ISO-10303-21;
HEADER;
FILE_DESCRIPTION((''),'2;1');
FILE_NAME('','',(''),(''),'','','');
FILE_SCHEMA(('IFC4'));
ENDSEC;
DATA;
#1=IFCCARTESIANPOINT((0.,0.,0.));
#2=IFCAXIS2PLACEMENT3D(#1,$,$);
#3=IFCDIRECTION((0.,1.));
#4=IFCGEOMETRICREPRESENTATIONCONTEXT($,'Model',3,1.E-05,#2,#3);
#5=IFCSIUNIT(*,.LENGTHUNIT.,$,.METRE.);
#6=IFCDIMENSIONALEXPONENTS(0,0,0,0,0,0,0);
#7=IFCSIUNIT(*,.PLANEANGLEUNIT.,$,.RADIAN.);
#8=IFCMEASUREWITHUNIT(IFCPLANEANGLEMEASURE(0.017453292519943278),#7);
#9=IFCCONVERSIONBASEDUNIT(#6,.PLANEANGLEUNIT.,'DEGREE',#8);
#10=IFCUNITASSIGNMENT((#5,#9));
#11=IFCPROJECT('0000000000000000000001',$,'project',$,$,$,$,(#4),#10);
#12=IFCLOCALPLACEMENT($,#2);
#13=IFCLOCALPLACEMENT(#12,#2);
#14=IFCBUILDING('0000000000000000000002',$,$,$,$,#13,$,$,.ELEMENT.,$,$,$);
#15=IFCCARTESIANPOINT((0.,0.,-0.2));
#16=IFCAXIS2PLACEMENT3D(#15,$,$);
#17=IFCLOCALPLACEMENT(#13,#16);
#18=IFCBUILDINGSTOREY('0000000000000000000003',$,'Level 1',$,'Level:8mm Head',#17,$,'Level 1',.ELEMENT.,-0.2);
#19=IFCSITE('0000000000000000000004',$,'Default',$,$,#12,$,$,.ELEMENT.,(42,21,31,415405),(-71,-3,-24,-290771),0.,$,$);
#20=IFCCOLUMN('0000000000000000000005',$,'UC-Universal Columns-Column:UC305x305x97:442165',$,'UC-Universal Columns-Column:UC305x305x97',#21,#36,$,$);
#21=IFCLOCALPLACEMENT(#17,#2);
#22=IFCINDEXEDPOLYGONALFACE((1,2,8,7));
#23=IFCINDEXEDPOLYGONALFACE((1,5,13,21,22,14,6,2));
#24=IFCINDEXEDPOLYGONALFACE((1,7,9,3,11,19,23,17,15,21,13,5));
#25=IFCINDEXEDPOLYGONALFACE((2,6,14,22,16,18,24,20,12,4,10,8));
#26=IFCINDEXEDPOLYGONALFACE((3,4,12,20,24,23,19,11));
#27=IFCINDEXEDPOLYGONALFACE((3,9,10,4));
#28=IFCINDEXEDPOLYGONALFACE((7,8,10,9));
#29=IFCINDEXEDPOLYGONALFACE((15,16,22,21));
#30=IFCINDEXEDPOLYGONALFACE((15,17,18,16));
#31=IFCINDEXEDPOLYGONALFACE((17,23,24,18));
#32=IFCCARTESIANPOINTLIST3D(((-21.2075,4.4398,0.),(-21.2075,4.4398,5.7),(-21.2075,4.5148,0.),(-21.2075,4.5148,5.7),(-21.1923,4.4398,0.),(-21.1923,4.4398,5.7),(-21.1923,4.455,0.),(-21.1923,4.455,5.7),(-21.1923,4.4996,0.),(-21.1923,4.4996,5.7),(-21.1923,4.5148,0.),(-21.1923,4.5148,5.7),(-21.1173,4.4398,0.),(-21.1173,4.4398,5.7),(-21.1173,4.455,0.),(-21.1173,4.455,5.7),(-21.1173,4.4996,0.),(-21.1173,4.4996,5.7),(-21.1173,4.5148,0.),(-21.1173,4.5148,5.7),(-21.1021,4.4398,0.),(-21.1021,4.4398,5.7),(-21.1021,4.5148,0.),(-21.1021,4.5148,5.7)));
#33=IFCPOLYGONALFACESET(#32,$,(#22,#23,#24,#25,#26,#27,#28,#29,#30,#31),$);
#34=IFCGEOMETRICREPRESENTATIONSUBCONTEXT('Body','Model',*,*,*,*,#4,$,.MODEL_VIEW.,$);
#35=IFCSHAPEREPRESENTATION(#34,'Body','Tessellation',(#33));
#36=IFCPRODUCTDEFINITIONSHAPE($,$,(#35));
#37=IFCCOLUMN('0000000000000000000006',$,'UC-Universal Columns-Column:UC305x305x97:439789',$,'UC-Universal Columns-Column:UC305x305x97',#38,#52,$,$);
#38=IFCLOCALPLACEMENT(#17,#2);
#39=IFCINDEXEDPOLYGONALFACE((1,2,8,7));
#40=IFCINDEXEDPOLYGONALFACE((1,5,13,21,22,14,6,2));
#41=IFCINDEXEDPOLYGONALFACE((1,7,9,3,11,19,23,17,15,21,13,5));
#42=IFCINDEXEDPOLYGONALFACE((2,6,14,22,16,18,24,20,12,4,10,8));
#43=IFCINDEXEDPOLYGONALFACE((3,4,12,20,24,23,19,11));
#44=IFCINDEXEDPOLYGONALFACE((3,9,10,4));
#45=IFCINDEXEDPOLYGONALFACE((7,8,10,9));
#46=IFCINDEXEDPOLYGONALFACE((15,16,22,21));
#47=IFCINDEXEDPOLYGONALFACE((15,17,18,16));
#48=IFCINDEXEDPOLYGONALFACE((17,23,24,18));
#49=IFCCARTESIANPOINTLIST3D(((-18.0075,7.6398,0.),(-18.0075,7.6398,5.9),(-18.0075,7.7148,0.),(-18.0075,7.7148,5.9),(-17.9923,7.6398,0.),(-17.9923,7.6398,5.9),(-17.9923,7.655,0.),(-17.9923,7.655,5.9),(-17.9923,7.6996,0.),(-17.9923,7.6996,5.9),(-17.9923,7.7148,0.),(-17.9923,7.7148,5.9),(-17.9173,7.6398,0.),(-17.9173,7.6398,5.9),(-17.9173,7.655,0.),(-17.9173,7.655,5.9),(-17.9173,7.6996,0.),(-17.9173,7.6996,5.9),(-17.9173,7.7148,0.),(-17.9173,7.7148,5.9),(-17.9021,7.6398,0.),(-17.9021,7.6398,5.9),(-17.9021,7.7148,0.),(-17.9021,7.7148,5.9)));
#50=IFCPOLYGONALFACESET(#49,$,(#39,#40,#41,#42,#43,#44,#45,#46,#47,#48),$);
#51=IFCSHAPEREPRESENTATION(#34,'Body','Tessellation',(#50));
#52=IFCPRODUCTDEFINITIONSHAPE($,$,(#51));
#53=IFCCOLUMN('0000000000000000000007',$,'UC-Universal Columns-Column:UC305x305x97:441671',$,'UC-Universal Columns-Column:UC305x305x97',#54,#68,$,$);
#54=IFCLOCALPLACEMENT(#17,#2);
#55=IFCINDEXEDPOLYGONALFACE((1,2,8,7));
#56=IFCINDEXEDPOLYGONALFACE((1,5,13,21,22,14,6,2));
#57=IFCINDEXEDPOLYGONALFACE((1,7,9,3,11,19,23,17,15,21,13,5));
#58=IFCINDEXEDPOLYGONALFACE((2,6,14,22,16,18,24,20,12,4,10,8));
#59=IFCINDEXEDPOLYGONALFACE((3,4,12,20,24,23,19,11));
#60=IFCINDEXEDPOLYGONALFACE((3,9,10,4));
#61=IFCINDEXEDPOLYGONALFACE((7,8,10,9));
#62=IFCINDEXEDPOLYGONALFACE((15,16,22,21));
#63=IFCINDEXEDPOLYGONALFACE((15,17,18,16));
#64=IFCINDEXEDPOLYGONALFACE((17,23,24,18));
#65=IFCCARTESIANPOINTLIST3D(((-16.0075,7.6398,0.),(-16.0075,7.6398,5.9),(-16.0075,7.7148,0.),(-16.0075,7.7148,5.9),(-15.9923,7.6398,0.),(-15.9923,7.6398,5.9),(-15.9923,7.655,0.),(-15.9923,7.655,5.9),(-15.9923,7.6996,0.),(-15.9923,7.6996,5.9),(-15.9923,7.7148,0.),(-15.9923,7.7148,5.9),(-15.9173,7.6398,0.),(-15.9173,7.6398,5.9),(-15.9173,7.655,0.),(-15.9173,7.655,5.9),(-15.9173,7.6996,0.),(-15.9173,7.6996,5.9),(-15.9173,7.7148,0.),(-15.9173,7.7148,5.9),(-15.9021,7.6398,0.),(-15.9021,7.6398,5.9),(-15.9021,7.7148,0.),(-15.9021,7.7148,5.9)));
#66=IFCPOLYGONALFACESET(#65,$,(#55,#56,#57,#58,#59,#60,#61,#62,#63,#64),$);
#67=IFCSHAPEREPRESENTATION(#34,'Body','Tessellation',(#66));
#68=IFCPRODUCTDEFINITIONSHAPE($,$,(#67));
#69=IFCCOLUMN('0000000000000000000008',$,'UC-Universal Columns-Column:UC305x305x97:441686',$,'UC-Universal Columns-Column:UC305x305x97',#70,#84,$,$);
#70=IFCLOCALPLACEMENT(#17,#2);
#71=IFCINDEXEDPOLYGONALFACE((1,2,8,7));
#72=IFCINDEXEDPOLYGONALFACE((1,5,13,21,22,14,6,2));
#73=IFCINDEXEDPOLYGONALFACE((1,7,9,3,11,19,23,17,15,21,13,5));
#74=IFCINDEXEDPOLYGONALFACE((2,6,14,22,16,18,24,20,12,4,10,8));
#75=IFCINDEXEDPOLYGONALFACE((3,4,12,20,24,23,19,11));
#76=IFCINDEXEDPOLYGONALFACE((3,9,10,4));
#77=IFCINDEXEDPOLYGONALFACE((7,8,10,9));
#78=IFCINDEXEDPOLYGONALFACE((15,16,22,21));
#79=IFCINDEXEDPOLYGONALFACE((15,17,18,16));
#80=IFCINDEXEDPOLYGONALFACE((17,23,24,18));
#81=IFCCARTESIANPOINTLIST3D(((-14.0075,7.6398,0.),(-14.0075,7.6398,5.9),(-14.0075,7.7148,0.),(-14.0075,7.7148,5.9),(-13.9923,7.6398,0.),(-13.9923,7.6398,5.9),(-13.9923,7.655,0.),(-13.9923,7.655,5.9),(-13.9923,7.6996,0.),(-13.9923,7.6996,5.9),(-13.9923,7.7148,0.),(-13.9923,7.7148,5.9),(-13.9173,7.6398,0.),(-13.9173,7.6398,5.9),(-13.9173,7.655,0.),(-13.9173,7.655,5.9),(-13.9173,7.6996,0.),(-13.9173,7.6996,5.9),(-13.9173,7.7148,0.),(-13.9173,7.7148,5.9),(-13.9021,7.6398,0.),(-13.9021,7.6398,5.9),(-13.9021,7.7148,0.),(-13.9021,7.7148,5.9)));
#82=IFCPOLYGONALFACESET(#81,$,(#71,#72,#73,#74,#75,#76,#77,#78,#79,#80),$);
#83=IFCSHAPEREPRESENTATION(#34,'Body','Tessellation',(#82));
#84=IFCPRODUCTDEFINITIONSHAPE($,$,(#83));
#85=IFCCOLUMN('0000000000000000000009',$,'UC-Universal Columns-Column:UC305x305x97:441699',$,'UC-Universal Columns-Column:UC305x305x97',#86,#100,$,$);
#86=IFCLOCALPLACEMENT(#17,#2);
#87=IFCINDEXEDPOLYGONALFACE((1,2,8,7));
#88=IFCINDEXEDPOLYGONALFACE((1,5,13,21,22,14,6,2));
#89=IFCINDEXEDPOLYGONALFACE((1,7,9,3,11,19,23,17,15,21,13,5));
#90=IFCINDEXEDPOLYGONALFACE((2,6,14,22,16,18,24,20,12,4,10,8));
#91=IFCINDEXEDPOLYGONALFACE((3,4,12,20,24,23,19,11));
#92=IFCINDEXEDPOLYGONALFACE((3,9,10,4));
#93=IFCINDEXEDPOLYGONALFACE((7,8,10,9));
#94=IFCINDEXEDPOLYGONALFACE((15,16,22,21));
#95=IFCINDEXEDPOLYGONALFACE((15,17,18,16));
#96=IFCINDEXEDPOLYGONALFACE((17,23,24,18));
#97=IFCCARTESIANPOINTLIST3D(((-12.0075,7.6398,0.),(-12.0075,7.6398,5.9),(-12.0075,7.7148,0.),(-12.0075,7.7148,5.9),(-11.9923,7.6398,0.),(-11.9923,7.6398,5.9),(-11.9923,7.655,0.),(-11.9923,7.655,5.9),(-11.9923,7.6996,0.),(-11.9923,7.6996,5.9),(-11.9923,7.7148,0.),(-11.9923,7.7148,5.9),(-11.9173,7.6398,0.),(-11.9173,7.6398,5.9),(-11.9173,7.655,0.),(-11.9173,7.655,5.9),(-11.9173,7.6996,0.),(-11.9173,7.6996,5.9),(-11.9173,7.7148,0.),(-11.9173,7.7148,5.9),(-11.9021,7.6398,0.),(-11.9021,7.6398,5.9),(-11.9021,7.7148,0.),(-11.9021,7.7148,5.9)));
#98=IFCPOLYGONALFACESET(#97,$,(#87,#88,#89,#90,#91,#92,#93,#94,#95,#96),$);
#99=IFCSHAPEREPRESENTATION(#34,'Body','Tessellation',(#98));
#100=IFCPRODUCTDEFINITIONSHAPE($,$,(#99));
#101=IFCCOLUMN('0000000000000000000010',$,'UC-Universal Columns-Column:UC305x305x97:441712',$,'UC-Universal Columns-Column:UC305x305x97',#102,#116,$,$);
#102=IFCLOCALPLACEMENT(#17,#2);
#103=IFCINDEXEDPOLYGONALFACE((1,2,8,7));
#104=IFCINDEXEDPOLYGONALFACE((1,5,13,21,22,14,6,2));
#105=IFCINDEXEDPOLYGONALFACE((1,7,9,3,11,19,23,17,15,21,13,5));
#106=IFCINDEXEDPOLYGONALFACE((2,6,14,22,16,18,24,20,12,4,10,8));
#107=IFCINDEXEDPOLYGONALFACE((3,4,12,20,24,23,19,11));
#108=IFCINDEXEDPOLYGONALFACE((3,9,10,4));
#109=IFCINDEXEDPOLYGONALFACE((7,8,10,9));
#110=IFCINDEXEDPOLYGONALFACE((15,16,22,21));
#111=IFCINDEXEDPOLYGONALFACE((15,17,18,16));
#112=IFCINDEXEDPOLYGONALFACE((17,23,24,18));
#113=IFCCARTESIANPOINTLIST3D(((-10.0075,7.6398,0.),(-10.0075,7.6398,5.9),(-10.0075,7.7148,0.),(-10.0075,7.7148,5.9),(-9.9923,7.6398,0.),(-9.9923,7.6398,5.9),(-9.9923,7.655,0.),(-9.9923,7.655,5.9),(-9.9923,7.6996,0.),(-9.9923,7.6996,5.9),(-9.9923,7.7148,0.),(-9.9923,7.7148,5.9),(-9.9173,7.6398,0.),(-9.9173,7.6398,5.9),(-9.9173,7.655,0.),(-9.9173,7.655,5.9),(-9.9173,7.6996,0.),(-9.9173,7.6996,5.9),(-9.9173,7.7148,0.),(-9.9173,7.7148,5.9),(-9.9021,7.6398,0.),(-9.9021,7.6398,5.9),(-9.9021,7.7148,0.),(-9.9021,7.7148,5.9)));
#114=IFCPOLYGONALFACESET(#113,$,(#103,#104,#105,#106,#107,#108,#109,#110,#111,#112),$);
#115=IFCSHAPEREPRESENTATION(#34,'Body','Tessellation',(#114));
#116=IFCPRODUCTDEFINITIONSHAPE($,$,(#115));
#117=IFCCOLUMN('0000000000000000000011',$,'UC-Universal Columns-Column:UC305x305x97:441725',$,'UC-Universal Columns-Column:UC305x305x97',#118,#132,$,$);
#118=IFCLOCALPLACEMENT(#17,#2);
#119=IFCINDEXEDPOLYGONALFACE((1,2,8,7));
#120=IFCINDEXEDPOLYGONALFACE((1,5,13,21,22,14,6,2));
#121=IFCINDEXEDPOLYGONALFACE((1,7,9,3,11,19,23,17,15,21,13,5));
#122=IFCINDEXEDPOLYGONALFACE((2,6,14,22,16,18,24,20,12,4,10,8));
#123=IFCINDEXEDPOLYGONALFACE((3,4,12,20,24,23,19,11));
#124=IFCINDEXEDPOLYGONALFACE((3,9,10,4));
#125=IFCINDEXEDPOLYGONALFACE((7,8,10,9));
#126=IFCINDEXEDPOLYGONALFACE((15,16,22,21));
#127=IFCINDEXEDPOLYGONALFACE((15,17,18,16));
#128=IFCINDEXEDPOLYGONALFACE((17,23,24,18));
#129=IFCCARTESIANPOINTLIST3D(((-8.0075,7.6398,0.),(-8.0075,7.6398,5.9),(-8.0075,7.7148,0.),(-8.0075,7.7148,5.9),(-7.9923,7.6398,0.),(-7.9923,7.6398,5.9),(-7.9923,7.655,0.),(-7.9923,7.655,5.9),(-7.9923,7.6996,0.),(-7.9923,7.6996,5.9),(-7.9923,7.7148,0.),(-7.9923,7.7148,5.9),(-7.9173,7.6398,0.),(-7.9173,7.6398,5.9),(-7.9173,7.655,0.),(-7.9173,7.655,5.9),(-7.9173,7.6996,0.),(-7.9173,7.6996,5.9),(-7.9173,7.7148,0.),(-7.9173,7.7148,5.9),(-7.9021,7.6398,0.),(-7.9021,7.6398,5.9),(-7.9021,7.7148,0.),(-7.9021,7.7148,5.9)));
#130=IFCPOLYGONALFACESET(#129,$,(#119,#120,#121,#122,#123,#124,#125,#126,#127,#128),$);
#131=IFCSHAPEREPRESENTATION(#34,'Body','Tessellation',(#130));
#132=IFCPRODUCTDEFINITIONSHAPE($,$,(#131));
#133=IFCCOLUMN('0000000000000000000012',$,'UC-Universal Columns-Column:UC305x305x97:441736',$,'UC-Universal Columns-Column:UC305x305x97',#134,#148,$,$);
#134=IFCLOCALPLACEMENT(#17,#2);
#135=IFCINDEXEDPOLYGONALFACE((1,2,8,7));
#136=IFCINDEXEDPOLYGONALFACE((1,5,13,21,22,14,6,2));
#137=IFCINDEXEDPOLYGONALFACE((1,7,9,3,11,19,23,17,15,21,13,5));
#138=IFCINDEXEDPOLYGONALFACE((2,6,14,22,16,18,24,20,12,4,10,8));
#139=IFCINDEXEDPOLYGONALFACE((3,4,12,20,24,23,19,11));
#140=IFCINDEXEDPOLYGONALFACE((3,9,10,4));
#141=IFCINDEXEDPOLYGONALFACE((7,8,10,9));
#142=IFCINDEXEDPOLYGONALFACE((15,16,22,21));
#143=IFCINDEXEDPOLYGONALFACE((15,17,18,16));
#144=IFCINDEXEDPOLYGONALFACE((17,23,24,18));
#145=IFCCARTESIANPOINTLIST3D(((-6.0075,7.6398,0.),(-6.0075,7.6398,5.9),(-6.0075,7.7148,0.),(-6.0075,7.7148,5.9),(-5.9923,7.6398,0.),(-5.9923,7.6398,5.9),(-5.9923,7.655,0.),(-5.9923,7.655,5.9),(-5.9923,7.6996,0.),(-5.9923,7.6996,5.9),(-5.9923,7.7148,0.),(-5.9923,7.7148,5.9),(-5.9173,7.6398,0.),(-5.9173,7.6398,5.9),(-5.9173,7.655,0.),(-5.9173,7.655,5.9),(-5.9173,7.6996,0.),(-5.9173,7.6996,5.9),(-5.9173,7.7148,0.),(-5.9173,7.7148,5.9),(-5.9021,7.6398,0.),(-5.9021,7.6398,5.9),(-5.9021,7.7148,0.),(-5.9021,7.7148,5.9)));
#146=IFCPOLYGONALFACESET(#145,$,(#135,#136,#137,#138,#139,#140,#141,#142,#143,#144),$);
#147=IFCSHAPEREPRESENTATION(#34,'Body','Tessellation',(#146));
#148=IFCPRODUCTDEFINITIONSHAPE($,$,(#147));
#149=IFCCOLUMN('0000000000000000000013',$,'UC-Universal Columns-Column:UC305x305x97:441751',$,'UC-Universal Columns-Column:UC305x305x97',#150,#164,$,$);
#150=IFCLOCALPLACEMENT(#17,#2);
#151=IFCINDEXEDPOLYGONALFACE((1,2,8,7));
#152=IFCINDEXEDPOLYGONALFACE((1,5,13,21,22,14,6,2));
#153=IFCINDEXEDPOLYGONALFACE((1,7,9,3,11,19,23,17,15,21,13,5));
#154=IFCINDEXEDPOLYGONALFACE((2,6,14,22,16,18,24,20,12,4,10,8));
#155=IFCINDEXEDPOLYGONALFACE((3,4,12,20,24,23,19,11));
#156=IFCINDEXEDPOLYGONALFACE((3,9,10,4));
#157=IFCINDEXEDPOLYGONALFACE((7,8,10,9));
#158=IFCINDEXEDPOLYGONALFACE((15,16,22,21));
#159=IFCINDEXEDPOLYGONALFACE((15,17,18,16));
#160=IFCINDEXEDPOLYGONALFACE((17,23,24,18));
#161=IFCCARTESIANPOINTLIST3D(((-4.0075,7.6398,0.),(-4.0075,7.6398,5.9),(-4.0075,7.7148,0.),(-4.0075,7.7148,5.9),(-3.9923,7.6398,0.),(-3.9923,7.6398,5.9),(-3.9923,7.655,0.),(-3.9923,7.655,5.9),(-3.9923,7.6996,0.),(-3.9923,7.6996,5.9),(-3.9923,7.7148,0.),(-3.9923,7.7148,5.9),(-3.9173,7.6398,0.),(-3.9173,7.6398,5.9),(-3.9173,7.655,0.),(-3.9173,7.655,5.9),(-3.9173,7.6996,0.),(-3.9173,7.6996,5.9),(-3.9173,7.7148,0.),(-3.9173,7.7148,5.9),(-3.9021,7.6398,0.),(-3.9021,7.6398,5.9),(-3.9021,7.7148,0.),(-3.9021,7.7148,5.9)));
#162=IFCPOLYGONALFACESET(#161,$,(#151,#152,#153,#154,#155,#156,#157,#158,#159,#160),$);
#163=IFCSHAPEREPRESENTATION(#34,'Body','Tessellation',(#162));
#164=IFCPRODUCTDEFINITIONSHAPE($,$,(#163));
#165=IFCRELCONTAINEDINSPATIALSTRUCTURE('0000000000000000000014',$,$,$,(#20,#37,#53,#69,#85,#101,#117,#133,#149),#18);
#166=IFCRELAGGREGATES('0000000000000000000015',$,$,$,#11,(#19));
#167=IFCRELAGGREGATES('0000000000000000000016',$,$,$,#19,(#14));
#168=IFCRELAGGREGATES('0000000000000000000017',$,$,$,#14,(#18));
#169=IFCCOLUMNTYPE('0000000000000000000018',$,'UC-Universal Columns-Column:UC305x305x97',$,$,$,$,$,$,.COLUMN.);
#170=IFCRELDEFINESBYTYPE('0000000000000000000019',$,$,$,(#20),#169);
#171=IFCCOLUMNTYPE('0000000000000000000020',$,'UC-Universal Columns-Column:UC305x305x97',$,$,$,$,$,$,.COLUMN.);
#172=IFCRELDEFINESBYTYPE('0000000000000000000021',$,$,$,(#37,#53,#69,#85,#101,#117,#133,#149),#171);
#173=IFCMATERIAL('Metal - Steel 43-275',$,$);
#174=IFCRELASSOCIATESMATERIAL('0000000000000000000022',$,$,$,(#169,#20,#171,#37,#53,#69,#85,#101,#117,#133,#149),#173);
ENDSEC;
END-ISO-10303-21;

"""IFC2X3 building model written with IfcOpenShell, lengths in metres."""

from ifc_helpers import new_model, entity, si_unit, converted_unit, direction, frame, frame_2d, origin, place, context, subcontext, project, spatial, polyline, circle_curve, parameter, trimmed, segment, composite_curve, outline, extrude, source, transform, mapped, material, type_object, type_shapes, element, save


model = new_model("IFC2X3")

# Units and contexts
model_context = context("Model", 3, precision=1e-05, world=origin(), true_north=direction((0.0, 1.0)))
body_context = subcontext(model_context, "Body", "Model", "MODEL_VIEW")
ifc_project = project(units=[si_unit("LENGTHUNIT", "METRE"), converted_unit("PLANEANGLEUNIT", "DEGREE", entity("IfcPlaneAngleMeasure", 0.017453292519943278), si_unit("PLANEANGLEUNIT", "RADIAN"), dimensions=[0, 0, 0, 0, 0, 0, 0])], contexts=[model_context])

# Site, building, storey
site_placement = place(None, origin())
site = spatial("IfcSite", under=ifc_project, at=site_placement, Name="Default", CompositionType="ELEMENT", RefLatitude=(42, 21, 31, 415405), RefLongitude=(-71, -3, -24, -290771), RefElevation=0.0)
building_placement = place(site_placement, origin())
building = spatial("IfcBuilding", under=site, at=building_placement, CompositionType="ELEMENT")
storey_placement = place(building_placement, frame((0.0, 0.0, -0.2)))
storey = spatial("IfcBuildingStorey", under=building, at=storey_placement, Name="Level 1", ObjectType="Level:8mm Head", LongName="Level 1", CompositionType="ELEMENT", Elevation=-0.2)

# Columns
ifc_material_1 = material(Name="Metal - Steel 43-275")
column_type_1 = type_object("IfcColumnType", Name="UC-Universal Columns-Column:UC305x305x97", PredefinedType="COLUMN", material=ifc_material_1)
shared_shape_1 = source(origin(), body_context, "Body", "SweptSolid", [
    extrude(outline(composite_curve([segment(polyline([(-0.0375, -0.0375), (0.0375, -0.0375)]), True, "CONTINUOUS"), segment(polyline([(0.0375, -0.0375), (0.0527, -0.0375)]), True, "CONTINUOUS"), segment(trimmed(circle_curve(frame_2d((0.0527, -0.0223), x_axis=(-1.0, 0.0)), 0.0152), [parameter(0.0)], [parameter(90.0)], True, "PARAMETER"), False, "CONTINUOUS"), segment(polyline([(0.0375, -0.0223), (0.0375, 0.0223)]), True, "CONTINUOUS"), segment(trimmed(circle_curve(frame_2d((0.0527, 0.0223), x_axis=(-1.0, 0.0)), 0.0152), [parameter(270.0)], [parameter(0.0)], True, "PARAMETER"), False, "CONTINUOUS"), segment(polyline([(0.0527, 0.0375), (0.0375, 0.0375)]), True, "CONTINUOUS"), segment(polyline([(0.0375, 0.0375), (-0.0375, 0.0375)]), True, "CONTINUOUS"), segment(polyline([(-0.0375, 0.0375), (-0.0527, 0.0375)]), True, "CONTINUOUS"), segment(trimmed(circle_curve(frame_2d((-0.0527, 0.0223), x_axis=(-1.0, 0.0)), 0.0152), [parameter(180.0)], [parameter(270.0)], True, "PARAMETER"), False, "CONTINUOUS"), segment(polyline([(-0.0375, 0.0223), (-0.0375, -0.0223)]), True, "CONTINUOUS"), segment(trimmed(circle_curve(frame_2d((-0.0527, -0.0223), x_axis=(-1.0, 0.0)), 0.0152), [parameter(90.0)], [parameter(180.0)], True, "PARAMETER"), False, "CONTINUOUS"), segment(polyline([(-0.0527, -0.0375), (-0.0375, -0.0375)]), True, "CONTINUOUS")], self_intersect=False)), frame((0.0, 0.0, -0.2), z_axis=(0.0, 0.0, 1.0), x_axis=(-1.0, 0.0, 0.0)), (0.0, 0.0, 1.0), 5.7),
])
type_shapes(column_type_1, [shared_shape_1])
for number, where, z_axis, x_axis, name in (
    (1, (-21.1548, 4.4773, 0.2), (0.0, 0.0, 1.0), (-1.0, 0.0, 0.0), "UC-Universal Columns-Column:UC305x305x97:442165"),
):
    element("IfcColumn", number, at=place(storey_placement, frame(where, z_axis=z_axis, x_axis=x_axis)), inside=storey, type_object=column_type_1, material=ifc_material_1, Name=name, ObjectType="UC-Universal Columns-Column:UC305x305x97", context=body_context, shape_type="MappedRepresentation", body=[
        mapped(shared_shape_1, transform((0.0, 0.0, 0.0), scale=1.0)),
    ])
column_type_2 = type_object("IfcColumnType", Name="UC-Universal Columns-Column:UC305x305x97", PredefinedType="COLUMN", material=ifc_material_1)
shared_shape_2 = source(origin(), body_context, "Body", "SweptSolid", [
    extrude(outline(composite_curve([segment(polyline([(-0.0375, -0.0375), (0.0375, -0.0375)]), True, "CONTINUOUS"), segment(polyline([(0.0375, -0.0375), (0.0527, -0.0375)]), True, "CONTINUOUS"), segment(trimmed(circle_curve(frame_2d((0.0527, -0.0223), x_axis=(-1.0, 0.0)), 0.0152), [parameter(0.0)], [parameter(90.0)], True, "PARAMETER"), False, "CONTINUOUS"), segment(polyline([(0.0375, -0.0223), (0.0375, 0.0223)]), True, "CONTINUOUS"), segment(trimmed(circle_curve(frame_2d((0.0527, 0.0223), x_axis=(-1.0, 0.0)), 0.0152), [parameter(270.0)], [parameter(0.0)], True, "PARAMETER"), False, "CONTINUOUS"), segment(polyline([(0.0527, 0.0375), (0.0375, 0.0375)]), True, "CONTINUOUS"), segment(polyline([(0.0375, 0.0375), (-0.0375, 0.0375)]), True, "CONTINUOUS"), segment(polyline([(-0.0375, 0.0375), (-0.0527, 0.0375)]), True, "CONTINUOUS"), segment(trimmed(circle_curve(frame_2d((-0.0527, 0.0223), x_axis=(-1.0, 0.0)), 0.0152), [parameter(180.0)], [parameter(270.0)], True, "PARAMETER"), False, "CONTINUOUS"), segment(polyline([(-0.0375, 0.0223), (-0.0375, -0.0223)]), True, "CONTINUOUS"), segment(trimmed(circle_curve(frame_2d((-0.0527, -0.0223), x_axis=(-1.0, 0.0)), 0.0152), [parameter(90.0)], [parameter(180.0)], True, "PARAMETER"), False, "CONTINUOUS"), segment(polyline([(-0.0527, -0.0375), (-0.0375, -0.0375)]), True, "CONTINUOUS")], self_intersect=False)), frame((0.0, 0.0, -0.2), z_axis=(0.0, 0.0, 1.0), x_axis=(-1.0, 0.0, 0.0)), (0.0, 0.0, 1.0), 5.9),
])
type_shapes(column_type_2, [shared_shape_2])
for number, where, z_axis, x_axis, name in (
    (2, (-17.9548, 7.6773, 0.2), (0.0, 0.0, 1.0), (-1.0, 0.0, 0.0), "UC-Universal Columns-Column:UC305x305x97:439789"),
    (3, (-15.9548, 7.6773, 0.2), (0.0, 0.0, 1.0), (-1.0, 0.0, 0.0), "UC-Universal Columns-Column:UC305x305x97:441671"),
    (4, (-13.9548, 7.6773, 0.2), (0.0, 0.0, 1.0), (-1.0, 0.0, 0.0), "UC-Universal Columns-Column:UC305x305x97:441686"),
    (5, (-11.9548, 7.6773, 0.2), (0.0, 0.0, 1.0), (-1.0, 0.0, 0.0), "UC-Universal Columns-Column:UC305x305x97:441699"),
    (6, (-9.9548, 7.6773, 0.2), (0.0, 0.0, 1.0), (-1.0, 0.0, 0.0), "UC-Universal Columns-Column:UC305x305x97:441712"),
    (7, (-7.9548, 7.6773, 0.2), (0.0, 0.0, 1.0), (-1.0, 0.0, 0.0), "UC-Universal Columns-Column:UC305x305x97:441725"),
    (8, (-5.9548, 7.6773, 0.2), (0.0, 0.0, 1.0), (-1.0, 0.0, 0.0), "UC-Universal Columns-Column:UC305x305x97:441736"),
    (9, (-3.9548, 7.6773, 0.2), (0.0, 0.0, 1.0), (-1.0, 0.0, 0.0), "UC-Universal Columns-Column:UC305x305x97:441751"),
):
    element("IfcColumn", number, at=place(storey_placement, frame(where, z_axis=z_axis, x_axis=x_axis)), inside=storey, type_object=column_type_2, material=ifc_material_1, Name=name, ObjectType="UC-Universal Columns-Column:UC305x305x97", context=body_context, shape_type="MappedRepresentation", body=[
        mapped(shared_shape_2, transform((0.0, 0.0, 0.0), scale=1.0)),
    ])

save(model, "model.ifc")
